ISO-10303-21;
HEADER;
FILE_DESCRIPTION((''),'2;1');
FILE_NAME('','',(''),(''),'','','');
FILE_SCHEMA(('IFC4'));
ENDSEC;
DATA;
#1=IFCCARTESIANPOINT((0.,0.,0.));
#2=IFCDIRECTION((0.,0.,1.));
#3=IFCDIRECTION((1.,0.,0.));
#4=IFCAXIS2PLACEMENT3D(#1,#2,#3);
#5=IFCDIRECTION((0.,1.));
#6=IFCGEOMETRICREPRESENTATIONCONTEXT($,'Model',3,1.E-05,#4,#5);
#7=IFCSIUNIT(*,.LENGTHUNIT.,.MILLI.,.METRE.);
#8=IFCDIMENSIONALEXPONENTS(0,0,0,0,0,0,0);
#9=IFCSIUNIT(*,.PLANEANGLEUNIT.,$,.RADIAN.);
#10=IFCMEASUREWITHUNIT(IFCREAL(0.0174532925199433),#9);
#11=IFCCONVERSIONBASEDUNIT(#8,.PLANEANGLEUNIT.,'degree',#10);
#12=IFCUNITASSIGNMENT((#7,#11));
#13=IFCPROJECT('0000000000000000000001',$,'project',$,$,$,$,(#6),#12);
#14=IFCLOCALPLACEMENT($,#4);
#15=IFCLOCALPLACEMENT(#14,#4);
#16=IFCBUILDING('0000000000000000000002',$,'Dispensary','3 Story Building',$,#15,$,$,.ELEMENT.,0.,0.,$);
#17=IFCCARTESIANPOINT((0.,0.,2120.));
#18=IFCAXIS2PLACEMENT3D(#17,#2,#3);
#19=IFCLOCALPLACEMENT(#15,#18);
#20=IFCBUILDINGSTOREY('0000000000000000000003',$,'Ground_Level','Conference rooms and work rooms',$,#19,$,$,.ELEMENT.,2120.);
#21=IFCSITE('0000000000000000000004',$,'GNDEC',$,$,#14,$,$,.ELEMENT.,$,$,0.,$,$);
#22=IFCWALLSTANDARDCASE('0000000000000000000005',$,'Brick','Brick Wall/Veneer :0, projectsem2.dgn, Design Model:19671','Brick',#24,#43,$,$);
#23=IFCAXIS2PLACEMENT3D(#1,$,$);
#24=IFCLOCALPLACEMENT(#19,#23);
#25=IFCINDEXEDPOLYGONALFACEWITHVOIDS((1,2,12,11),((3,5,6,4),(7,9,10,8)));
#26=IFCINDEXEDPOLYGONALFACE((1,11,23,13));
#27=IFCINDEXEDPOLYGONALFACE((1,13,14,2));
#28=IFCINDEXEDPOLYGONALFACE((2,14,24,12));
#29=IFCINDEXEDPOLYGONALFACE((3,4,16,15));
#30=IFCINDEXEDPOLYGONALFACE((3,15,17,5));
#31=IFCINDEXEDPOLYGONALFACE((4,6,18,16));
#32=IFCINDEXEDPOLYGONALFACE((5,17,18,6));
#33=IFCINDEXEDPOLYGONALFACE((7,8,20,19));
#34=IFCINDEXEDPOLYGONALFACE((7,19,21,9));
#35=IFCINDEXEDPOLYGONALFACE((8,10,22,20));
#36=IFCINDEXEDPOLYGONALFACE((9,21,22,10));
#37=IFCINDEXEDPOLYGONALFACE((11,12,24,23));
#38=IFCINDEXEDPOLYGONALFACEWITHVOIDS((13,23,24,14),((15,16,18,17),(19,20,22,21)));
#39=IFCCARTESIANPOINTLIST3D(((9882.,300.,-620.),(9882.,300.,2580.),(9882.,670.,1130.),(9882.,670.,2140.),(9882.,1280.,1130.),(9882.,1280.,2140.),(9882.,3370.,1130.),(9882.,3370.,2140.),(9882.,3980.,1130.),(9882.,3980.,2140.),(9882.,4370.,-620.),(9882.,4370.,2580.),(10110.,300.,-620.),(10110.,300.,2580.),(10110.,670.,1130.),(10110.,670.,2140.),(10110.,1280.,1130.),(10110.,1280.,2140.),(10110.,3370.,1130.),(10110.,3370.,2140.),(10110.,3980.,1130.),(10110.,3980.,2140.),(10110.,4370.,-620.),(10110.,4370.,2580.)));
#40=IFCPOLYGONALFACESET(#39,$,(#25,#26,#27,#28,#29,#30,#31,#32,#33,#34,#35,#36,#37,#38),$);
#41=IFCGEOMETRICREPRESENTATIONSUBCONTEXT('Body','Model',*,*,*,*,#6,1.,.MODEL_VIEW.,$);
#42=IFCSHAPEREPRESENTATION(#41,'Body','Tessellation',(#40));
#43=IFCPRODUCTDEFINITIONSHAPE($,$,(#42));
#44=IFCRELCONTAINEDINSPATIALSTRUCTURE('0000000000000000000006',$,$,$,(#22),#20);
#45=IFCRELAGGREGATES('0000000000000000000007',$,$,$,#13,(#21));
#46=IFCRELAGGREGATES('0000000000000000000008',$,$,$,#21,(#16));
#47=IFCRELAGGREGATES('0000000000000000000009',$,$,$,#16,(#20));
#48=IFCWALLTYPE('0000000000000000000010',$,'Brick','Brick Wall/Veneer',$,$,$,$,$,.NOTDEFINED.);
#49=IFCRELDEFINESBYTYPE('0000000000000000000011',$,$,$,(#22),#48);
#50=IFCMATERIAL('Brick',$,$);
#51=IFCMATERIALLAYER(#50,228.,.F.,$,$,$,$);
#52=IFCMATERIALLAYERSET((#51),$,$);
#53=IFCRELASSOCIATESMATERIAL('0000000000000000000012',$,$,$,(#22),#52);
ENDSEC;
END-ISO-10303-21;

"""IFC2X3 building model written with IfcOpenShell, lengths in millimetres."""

from ifc_helpers import new_model, entity, si_unit, converted_unit, direction, frame, frame_2d, origin_with_axes, place, context, subcontext, project, spatial, rectangle, extrude, material, layer, layer_set, layer_usage, type_object, element, save


model = new_model("IFC2X3")

# Units and contexts
model_context = context("Model", 3, precision=1e-05, world=origin_with_axes(), true_north=direction((0.0, 1.0)))
body_context = subcontext(model_context, "Body", "Model", "MODEL_VIEW", scale=1.0)
ifc_project = project(units=[si_unit("LENGTHUNIT", "METRE", prefix="MILLI"), converted_unit("PLANEANGLEUNIT", "degree", entity("IfcReal", 0.0174532925199433), si_unit("PLANEANGLEUNIT", "RADIAN"), dimensions=[0, 0, 0, 0, 0, 0, 0])], contexts=[model_context])

# Site, building, storey
site_placement = place(None, origin_with_axes())
site = spatial("IfcSite", under=ifc_project, at=site_placement, Name="GNDEC", CompositionType="ELEMENT", RefElevation=0.0)
building_placement = place(site_placement, origin_with_axes())
building = spatial("IfcBuilding", under=site, at=building_placement, Name="Dispensary", Description="3 Story Building", CompositionType="ELEMENT", ElevationOfRefHeight=0.0, ElevationOfTerrain=0.0)
storey_placement = place(building_placement, frame((0.0, 0.0, 2120.0), z_axis=(0.0, 0.0, 1.0), x_axis=(1.0, 0.0, 0.0)))
storey = spatial("IfcBuildingStorey", under=building, at=storey_placement, Name="Ground_Level", Description="Conference rooms and work rooms", CompositionType="ELEMENT", Elevation=2120.0)

# Wall, openings
ifc_material_1 = material(Name="Brick")
ifc_layer = layer(ifc_material_1, 228.0, ventilated=False)
ifc_layer_set = layer_set([ifc_layer])
ifc_layer_usage = layer_usage(ifc_layer_set, "AXIS2", "POSITIVE", 0.0)
wall_type = type_object("IfcWallType", Name="Brick", Description="Brick Wall/Veneer", PredefinedType="NOTDEFINED")
wall_1_placement = place(storey_placement, frame((10110.0, 4370.0, -620.0), z_axis=(0.0, 0.0, 1.0), x_axis=(0.0, -1.0, 0.0)))
wall_1 = element("IfcWallStandardCase", 1, at=wall_1_placement, inside=storey, type_object=wall_type, material=ifc_layer_usage, Name="Brick", Description="Brick Wall/Veneer :0, projectsem2.dgn, Design Model:19671", ObjectType="Brick", context=body_context, shape_type="SweptSolid", body=[
    extrude(rectangle(XDim=4070.0, YDim=228.0, at=frame_2d((2035.0, -114.0), x_axis=(-1.0, 0.0))), origin_with_axes(), (0.0, 0.0, 1.0), 3200.0),
])
opening_1_placement = place(wall_1_placement, frame((3090.0, -228.0, 1750.0), z_axis=(0.0, 0.0, 1.0), x_axis=(1.0, 0.0, 0.0)))
element("IfcOpeningElement", 2, at=opening_1_placement, cuts=wall_1, ObjectType="Opening", context=body_context, shape_type="SweptSolid", body=[
    extrude(rectangle(XDim=1010.0, YDim=610.0, at=frame_2d((-305.0, 505.0), x_axis=(0.0, -1.0))), frame((0.0, 0.0, 0.0), z_axis=(0.0, 1.0, 0.0), x_axis=(-1.0, 0.0, 0.0)), (0.0, 0.0, 1.0), 228.0),
])
opening_2_placement = place(wall_1_placement, frame((390.0, -228.0, 1750.0), z_axis=(0.0, 0.0, 1.0), x_axis=(1.0, 0.0, 0.0)))
element("IfcOpeningElement", 3, at=opening_2_placement, cuts=wall_1, ObjectType="Opening", context=body_context, shape_type="SweptSolid", body=[
    extrude(rectangle(XDim=1010.0, YDim=610.0, at=frame_2d((-305.0, 505.0), x_axis=(0.0, -1.0))), frame((0.0, 0.0, 0.0), z_axis=(0.0, 1.0, 0.0), x_axis=(-1.0, 0.0, 0.0)), (0.0, 0.0, 1.0), 228.0),
])

save(model, "model.ifc")
